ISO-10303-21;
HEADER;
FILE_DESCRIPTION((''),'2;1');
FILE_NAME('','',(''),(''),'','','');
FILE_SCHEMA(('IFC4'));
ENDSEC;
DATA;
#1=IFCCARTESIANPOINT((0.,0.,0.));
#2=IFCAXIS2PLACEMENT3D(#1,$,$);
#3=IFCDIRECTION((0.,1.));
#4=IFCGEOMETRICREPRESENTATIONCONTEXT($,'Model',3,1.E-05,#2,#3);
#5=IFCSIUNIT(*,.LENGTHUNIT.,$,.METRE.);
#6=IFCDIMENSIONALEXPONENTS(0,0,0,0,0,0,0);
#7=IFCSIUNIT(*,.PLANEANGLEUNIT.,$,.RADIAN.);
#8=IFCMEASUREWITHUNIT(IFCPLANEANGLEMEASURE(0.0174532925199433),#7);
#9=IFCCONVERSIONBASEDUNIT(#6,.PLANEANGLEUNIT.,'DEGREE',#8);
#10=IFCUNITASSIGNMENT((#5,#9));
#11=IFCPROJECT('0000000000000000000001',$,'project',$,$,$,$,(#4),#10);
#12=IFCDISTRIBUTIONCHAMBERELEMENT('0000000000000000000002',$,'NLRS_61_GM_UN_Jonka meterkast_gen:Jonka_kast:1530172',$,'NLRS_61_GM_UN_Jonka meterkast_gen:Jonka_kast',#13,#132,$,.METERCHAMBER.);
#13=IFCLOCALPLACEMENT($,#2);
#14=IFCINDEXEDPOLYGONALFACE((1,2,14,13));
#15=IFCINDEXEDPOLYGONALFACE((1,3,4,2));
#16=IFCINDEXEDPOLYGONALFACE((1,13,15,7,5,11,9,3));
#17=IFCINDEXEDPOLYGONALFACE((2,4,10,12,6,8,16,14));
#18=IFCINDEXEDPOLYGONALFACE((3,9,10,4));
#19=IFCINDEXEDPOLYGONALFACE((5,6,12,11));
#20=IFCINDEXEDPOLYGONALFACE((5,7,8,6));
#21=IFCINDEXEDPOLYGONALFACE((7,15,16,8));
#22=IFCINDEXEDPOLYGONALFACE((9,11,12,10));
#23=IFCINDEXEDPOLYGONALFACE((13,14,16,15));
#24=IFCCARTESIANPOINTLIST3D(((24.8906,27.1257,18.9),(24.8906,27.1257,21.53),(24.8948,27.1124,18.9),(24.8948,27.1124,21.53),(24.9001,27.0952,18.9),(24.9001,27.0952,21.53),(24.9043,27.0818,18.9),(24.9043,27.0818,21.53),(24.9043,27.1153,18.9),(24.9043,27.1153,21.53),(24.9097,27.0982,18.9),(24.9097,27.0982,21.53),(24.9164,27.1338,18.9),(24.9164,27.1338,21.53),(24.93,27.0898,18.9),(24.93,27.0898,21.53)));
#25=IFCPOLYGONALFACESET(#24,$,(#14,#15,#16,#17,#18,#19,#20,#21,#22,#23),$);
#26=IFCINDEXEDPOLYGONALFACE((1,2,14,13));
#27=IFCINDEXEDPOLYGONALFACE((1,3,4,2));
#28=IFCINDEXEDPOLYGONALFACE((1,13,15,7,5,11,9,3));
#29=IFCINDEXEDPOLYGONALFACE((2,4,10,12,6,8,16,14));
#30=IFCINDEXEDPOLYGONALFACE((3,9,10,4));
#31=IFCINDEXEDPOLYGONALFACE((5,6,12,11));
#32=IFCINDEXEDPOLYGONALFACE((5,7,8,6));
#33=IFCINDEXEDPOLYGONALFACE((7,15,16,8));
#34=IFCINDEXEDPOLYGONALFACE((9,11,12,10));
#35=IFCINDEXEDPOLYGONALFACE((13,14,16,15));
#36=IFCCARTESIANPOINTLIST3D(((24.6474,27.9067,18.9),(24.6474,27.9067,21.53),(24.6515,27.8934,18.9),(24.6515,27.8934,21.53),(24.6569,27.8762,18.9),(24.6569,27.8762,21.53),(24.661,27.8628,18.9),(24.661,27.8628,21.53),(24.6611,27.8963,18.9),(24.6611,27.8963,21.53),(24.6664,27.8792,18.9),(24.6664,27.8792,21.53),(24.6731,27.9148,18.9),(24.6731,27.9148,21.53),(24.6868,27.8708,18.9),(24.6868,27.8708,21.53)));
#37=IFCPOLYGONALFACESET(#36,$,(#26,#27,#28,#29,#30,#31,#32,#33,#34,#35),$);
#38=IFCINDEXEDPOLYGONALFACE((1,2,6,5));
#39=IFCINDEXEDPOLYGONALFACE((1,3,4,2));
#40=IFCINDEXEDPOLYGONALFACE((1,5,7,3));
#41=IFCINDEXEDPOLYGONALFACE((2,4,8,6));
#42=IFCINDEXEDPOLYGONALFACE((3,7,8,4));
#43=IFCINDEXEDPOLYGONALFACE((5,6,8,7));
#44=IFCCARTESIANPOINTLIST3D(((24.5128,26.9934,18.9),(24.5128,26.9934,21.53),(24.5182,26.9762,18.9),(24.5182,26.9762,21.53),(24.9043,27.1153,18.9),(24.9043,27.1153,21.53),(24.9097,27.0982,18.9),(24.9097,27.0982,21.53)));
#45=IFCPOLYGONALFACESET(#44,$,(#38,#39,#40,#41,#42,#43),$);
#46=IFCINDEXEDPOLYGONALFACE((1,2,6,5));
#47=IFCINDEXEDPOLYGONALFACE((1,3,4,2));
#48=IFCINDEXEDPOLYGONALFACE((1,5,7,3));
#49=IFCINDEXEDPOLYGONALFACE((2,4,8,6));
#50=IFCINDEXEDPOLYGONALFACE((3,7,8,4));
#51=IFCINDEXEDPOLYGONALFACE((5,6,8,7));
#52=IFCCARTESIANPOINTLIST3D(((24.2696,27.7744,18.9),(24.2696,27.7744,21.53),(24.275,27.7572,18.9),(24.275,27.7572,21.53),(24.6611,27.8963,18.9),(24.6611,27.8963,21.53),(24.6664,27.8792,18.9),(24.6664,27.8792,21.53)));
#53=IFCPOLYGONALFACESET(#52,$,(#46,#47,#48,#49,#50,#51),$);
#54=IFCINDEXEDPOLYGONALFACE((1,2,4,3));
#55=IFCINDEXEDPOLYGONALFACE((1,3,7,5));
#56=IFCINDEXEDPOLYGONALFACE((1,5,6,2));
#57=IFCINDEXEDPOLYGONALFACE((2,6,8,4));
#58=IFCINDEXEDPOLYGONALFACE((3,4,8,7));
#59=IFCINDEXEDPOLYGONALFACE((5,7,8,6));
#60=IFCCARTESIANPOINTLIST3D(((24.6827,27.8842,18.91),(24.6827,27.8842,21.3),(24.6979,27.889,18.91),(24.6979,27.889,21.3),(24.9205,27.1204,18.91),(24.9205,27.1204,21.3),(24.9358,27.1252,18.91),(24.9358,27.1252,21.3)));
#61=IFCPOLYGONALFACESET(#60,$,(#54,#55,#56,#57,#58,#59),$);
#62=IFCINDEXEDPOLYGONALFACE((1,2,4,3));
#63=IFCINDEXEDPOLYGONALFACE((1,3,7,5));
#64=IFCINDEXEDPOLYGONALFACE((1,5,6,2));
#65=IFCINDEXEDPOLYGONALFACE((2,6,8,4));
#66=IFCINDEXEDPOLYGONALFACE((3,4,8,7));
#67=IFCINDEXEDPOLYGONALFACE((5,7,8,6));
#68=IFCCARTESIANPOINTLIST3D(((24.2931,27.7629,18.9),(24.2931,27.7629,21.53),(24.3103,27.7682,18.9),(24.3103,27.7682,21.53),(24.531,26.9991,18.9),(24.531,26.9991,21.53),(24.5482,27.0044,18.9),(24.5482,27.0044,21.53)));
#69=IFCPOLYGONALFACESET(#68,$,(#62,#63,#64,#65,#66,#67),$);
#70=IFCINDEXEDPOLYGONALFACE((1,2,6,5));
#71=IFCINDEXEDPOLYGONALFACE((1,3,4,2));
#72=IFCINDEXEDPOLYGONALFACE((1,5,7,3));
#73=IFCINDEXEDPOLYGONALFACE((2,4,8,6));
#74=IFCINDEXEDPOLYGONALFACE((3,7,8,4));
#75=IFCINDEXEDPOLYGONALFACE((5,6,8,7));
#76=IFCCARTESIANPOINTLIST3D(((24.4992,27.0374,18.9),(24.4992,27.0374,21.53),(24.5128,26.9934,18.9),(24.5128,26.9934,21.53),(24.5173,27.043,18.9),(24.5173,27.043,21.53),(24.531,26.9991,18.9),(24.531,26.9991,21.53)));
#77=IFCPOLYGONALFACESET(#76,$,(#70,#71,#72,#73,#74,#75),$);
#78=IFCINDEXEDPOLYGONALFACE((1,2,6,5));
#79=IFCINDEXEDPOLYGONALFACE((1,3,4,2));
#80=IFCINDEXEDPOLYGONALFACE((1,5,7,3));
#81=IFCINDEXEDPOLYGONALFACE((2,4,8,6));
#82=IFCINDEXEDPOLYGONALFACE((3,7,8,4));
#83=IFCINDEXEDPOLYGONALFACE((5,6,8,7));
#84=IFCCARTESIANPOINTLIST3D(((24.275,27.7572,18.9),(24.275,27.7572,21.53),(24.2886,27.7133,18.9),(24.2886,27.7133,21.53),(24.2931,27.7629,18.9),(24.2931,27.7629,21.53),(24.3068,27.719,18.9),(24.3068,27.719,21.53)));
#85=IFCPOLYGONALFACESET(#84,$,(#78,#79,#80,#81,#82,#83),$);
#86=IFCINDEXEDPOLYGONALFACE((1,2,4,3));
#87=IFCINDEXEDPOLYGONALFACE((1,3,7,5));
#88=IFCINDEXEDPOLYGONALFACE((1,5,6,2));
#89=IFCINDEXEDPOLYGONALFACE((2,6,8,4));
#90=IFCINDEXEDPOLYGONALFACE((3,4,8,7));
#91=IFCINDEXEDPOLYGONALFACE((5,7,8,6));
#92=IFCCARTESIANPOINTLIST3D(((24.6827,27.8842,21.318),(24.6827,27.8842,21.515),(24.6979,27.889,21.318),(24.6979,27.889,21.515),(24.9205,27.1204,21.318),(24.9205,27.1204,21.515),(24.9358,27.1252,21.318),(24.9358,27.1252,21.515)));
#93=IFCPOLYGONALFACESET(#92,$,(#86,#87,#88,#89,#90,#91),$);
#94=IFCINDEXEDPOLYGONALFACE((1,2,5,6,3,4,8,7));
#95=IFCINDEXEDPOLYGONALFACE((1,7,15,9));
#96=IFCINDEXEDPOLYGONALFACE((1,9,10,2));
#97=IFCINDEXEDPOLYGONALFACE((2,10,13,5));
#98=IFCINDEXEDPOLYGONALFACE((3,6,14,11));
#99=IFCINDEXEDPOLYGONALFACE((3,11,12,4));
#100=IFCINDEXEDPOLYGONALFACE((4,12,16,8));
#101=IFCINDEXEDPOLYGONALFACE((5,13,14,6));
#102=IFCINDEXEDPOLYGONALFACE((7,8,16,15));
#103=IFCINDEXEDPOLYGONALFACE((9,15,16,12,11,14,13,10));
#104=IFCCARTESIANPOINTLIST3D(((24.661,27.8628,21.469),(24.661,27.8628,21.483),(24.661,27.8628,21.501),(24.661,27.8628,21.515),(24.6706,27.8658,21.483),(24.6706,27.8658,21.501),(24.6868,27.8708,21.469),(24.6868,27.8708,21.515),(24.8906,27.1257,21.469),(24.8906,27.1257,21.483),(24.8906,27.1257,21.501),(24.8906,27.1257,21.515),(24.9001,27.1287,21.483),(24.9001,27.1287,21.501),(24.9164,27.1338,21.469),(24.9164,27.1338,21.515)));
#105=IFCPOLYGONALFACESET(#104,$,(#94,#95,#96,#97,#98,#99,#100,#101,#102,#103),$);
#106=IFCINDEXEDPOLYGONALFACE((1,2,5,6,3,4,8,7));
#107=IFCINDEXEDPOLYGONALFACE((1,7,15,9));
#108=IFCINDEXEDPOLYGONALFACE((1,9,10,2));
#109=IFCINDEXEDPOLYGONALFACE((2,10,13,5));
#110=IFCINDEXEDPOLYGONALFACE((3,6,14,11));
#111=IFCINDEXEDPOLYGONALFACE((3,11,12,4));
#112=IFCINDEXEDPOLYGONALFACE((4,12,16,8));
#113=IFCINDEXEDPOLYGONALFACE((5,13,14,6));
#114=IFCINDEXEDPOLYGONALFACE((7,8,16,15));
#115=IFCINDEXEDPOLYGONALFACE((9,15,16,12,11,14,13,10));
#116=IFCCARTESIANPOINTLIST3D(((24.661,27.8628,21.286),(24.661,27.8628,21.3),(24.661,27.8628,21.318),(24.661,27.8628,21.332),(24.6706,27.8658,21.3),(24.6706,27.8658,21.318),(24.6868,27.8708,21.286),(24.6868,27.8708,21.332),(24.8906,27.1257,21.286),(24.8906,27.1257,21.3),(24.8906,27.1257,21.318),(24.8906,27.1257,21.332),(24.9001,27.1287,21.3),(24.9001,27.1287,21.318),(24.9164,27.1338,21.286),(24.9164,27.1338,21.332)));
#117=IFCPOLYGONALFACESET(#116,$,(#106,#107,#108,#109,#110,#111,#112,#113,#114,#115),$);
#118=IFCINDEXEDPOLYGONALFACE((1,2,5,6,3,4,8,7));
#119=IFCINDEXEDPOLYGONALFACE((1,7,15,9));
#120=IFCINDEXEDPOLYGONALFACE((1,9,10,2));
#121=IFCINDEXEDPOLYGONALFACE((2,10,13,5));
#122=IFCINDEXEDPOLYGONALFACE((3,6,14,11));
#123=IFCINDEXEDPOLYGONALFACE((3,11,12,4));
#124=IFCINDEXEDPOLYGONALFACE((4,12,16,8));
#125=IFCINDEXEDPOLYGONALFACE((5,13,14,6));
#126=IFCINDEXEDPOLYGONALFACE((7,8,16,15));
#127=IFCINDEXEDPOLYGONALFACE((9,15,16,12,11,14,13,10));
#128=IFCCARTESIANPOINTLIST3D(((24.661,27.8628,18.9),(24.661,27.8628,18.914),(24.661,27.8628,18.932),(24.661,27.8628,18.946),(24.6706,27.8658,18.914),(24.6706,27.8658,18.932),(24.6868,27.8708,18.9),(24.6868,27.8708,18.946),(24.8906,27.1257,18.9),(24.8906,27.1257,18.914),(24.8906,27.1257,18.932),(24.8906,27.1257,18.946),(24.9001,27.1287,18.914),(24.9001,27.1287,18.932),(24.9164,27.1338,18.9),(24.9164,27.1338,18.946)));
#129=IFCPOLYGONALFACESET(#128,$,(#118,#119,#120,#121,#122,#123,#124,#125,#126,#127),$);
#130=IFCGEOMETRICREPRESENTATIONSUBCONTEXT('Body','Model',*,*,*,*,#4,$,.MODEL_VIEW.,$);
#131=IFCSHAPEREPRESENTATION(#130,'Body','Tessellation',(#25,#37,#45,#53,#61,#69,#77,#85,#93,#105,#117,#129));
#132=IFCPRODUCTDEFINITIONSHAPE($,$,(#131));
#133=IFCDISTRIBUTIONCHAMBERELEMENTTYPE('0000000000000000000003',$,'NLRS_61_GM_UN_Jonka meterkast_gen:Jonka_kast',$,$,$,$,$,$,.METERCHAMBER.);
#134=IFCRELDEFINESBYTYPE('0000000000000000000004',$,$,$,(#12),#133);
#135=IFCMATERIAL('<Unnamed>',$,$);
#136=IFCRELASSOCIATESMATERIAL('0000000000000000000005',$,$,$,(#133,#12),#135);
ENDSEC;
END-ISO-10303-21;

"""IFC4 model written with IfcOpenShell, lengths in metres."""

from ifc_helpers import new_model, entity, si_unit, converted_unit, direction, frame, origin, place, context, subcontext, project, indexed_curve, outline, extrude, source, transform, mapped, material, type_object, type_shapes, element, save


model = new_model("IFC4")

# Units and contexts
model_context = context("Model", 3, precision=1e-05, world=origin(), true_north=direction((0.0, 1.0)))
body_context = subcontext(model_context, "Body", "Model", "MODEL_VIEW")
ifc_project = project(units=[si_unit("LENGTHUNIT", "METRE"), converted_unit("PLANEANGLEUNIT", "DEGREE", entity("IfcPlaneAngleMeasure", 0.0174532925199433), si_unit("PLANEANGLEUNIT", "RADIAN"), dimensions=[0, 0, 0, 0, 0, 0, 0])], contexts=[model_context])

# Distribution chamber element
ifc_material = material(Name="<Unnamed>")
distribution_chamber_element_type = type_object("IfcDistributionChamberElementType", Name="NLRS_61_GM_UN_Jonka meterkast_gen:Jonka_kast", PredefinedType="METERCHAMBER", material=ifc_material)
shared_shape_1 = source(origin(), body_context, "Body", "SweptSolid", [
    extrude(outline(indexed_curve([(-0.0093, -0.023), (0.0178, -0.023), (0.0178, 0.023), (-0.0093, 0.023), (-0.0093, 0.009), (0.0007, 0.009), (0.0007, -0.009), (-0.0093, -0.009), (-0.0093, -0.023)], self_intersect=False)), frame((-0.409, -0.4092, 0.0), z_axis=(0.0, 0.0, 1.0), x_axis=(0.0, -1.0, 0.0)), (0.0, 0.0, 1.0), 2.63),
    extrude(outline(indexed_curve([(-0.0093, -0.023), (0.0178, -0.023), (0.0178, 0.023), (-0.0093, 0.023), (-0.0093, 0.009), (0.0007, 0.009), (0.0007, -0.009), (-0.0093, -0.009), (-0.0093, -0.023)], self_intersect=False)), frame((0.409, -0.4092, 0.0), z_axis=(0.0, 0.0, 1.0), x_axis=(0.0, -1.0, 0.0)), (0.0, 0.0, 1.0), 2.63),
    extrude(outline(indexed_curve([(-0.205, -0.009), (0.205, -0.009), (0.205, 0.009), (-0.205, 0.009), (-0.205, -0.009)], self_intersect=False)), frame((-0.409, -0.205, 0.0), z_axis=(0.0, 0.0, 1.0), x_axis=(0.0, -1.0, 0.0)), (0.0, 0.0, 1.0), 2.63),
    extrude(outline(indexed_curve([(-0.205, -0.009), (0.205, -0.009), (0.205, 0.009), (-0.205, 0.009), (-0.205, -0.009)], self_intersect=False)), frame((0.409, -0.205, 0.0), z_axis=(0.0, 0.0, 1.0), x_axis=(0.0, -1.0, 0.0)), (0.0, 0.0, 1.0), 2.63),
    extrude(outline(indexed_curve([(-0.4, -0.008), (0.4, -0.008), (0.4, 0.008), (-0.4, 0.008), (-0.4, -0.008)], self_intersect=False)), frame((0.0, -0.435, 0.01), z_axis=(0.0, 0.0, 1.0), x_axis=(-1.0, 0.0, 0.0)), (0.0, 0.0, 1.0), 2.39),
    extrude(outline(indexed_curve([(-0.4, -0.009), (0.4, -0.009), (0.4, 0.009), (-0.4, 0.009), (-0.4, -0.009)], self_intersect=False)), frame((0.0, -0.028, 0.0), z_axis=(0.0, 0.0, 1.0), x_axis=(-1.0, 0.0, 0.0)), (0.0, 0.0, 1.0), 2.63),
    extrude(outline(indexed_curve([(-0.023, -0.0095), (0.023, -0.0095), (0.023, 0.0095), (-0.023, 0.0095), (-0.023, -0.0095)], self_intersect=False)), frame((-0.377, -0.0095, 0.0), z_axis=(0.0, 0.0, 1.0), x_axis=(-1.0, 0.0, 0.0)), (0.0, 0.0, 1.0), 2.63),
    extrude(outline(indexed_curve([(-0.023, -0.0095), (0.023, -0.0095), (0.023, 0.0095), (-0.023, 0.0095), (-0.023, -0.0095)], self_intersect=False)), frame((0.377, -0.0095, 0.0), z_axis=(0.0, 0.0, 1.0), x_axis=(-1.0, 0.0, 0.0)), (0.0, 0.0, 1.0), 2.63),
    extrude(outline(indexed_curve([(-0.4, -0.008), (0.4, -0.008), (0.4, 0.008), (-0.4, 0.008), (-0.4, -0.008)], self_intersect=False)), frame((0.0, -0.435, 2.418), z_axis=(0.0, 0.0, 1.0), x_axis=(-1.0, 0.0, 0.0)), (0.0, 0.0, 1.0), 0.197),
    extrude(outline(indexed_curve([(-0.023, -0.0178), (0.023, -0.0178), (0.023, 0.0093), (0.009, 0.0093), (0.009, -0.0007), (-0.009, -0.0007), (-0.009, 0.0093), (-0.023, 0.0093), (-0.023, -0.0178)], self_intersect=False)), frame((-0.386, -0.4092, 2.592), z_axis=(1.0, 0.0, 0.0), x_axis=(0.0, 0.0, -1.0)), (0.0, 0.0, 1.0), 0.772),
    extrude(outline(indexed_curve([(-0.023, -0.0178), (0.023, -0.0178), (0.023, 0.0093), (0.009, 0.0093), (0.009, -0.0007), (-0.009, -0.0007), (-0.009, 0.0093), (-0.023, 0.0093), (-0.023, -0.0178)], self_intersect=False)), frame((-0.386, -0.4092, 2.409), z_axis=(1.0, 0.0, 0.0), x_axis=(0.0, 0.0, -1.0)), (0.0, 0.0, 1.0), 0.772),
    extrude(outline(indexed_curve([(-0.023, -0.0178), (0.023, -0.0178), (0.023, 0.0093), (0.009, 0.0093), (0.009, -0.0007), (-0.009, -0.0007), (-0.009, 0.0093), (-0.023, 0.0093), (-0.023, -0.0178)], self_intersect=False)), frame((-0.386, -0.4092, 0.023), z_axis=(1.0, 0.0, 0.0), x_axis=(0.0, 0.0, -1.0)), (0.0, 0.0, 1.0), 0.772),
])
type_shapes(distribution_chamber_element_type, [shared_shape_1])
placement_1 = place(None, frame((13.1348, 11.9886, 0.0), z_axis=(0.0, 0.0, 1.0), x_axis=(0.954771, 0.297342, 0.0)))
placement_2 = place(placement_1, origin())
placement_3 = place(placement_2, frame((0.0, 0.0, 18.9)))
placement_4 = place(placement_3, origin())
distribution_chamber_element_1_placement = place(placement_4, frame((15.325, 11.343, 0.0), z_axis=(0.0, 0.0, 1.0), x_axis=(0.0, 1.0, 0.0)))
element("IfcDistributionChamberElement", 1, at=distribution_chamber_element_1_placement, type_object=distribution_chamber_element_type, material=ifc_material, Name="NLRS_61_GM_UN_Jonka meterkast_gen:Jonka_kast:1530172", ObjectType="NLRS_61_GM_UN_Jonka meterkast_gen:Jonka_kast", PredefinedType="METERCHAMBER", context=body_context, shape_type="MappedRepresentation", body=[
    mapped(shared_shape_1, transform((0.0, 0.0, 0.0), scale=1.0)),
])

save(model, "model.ifc")
